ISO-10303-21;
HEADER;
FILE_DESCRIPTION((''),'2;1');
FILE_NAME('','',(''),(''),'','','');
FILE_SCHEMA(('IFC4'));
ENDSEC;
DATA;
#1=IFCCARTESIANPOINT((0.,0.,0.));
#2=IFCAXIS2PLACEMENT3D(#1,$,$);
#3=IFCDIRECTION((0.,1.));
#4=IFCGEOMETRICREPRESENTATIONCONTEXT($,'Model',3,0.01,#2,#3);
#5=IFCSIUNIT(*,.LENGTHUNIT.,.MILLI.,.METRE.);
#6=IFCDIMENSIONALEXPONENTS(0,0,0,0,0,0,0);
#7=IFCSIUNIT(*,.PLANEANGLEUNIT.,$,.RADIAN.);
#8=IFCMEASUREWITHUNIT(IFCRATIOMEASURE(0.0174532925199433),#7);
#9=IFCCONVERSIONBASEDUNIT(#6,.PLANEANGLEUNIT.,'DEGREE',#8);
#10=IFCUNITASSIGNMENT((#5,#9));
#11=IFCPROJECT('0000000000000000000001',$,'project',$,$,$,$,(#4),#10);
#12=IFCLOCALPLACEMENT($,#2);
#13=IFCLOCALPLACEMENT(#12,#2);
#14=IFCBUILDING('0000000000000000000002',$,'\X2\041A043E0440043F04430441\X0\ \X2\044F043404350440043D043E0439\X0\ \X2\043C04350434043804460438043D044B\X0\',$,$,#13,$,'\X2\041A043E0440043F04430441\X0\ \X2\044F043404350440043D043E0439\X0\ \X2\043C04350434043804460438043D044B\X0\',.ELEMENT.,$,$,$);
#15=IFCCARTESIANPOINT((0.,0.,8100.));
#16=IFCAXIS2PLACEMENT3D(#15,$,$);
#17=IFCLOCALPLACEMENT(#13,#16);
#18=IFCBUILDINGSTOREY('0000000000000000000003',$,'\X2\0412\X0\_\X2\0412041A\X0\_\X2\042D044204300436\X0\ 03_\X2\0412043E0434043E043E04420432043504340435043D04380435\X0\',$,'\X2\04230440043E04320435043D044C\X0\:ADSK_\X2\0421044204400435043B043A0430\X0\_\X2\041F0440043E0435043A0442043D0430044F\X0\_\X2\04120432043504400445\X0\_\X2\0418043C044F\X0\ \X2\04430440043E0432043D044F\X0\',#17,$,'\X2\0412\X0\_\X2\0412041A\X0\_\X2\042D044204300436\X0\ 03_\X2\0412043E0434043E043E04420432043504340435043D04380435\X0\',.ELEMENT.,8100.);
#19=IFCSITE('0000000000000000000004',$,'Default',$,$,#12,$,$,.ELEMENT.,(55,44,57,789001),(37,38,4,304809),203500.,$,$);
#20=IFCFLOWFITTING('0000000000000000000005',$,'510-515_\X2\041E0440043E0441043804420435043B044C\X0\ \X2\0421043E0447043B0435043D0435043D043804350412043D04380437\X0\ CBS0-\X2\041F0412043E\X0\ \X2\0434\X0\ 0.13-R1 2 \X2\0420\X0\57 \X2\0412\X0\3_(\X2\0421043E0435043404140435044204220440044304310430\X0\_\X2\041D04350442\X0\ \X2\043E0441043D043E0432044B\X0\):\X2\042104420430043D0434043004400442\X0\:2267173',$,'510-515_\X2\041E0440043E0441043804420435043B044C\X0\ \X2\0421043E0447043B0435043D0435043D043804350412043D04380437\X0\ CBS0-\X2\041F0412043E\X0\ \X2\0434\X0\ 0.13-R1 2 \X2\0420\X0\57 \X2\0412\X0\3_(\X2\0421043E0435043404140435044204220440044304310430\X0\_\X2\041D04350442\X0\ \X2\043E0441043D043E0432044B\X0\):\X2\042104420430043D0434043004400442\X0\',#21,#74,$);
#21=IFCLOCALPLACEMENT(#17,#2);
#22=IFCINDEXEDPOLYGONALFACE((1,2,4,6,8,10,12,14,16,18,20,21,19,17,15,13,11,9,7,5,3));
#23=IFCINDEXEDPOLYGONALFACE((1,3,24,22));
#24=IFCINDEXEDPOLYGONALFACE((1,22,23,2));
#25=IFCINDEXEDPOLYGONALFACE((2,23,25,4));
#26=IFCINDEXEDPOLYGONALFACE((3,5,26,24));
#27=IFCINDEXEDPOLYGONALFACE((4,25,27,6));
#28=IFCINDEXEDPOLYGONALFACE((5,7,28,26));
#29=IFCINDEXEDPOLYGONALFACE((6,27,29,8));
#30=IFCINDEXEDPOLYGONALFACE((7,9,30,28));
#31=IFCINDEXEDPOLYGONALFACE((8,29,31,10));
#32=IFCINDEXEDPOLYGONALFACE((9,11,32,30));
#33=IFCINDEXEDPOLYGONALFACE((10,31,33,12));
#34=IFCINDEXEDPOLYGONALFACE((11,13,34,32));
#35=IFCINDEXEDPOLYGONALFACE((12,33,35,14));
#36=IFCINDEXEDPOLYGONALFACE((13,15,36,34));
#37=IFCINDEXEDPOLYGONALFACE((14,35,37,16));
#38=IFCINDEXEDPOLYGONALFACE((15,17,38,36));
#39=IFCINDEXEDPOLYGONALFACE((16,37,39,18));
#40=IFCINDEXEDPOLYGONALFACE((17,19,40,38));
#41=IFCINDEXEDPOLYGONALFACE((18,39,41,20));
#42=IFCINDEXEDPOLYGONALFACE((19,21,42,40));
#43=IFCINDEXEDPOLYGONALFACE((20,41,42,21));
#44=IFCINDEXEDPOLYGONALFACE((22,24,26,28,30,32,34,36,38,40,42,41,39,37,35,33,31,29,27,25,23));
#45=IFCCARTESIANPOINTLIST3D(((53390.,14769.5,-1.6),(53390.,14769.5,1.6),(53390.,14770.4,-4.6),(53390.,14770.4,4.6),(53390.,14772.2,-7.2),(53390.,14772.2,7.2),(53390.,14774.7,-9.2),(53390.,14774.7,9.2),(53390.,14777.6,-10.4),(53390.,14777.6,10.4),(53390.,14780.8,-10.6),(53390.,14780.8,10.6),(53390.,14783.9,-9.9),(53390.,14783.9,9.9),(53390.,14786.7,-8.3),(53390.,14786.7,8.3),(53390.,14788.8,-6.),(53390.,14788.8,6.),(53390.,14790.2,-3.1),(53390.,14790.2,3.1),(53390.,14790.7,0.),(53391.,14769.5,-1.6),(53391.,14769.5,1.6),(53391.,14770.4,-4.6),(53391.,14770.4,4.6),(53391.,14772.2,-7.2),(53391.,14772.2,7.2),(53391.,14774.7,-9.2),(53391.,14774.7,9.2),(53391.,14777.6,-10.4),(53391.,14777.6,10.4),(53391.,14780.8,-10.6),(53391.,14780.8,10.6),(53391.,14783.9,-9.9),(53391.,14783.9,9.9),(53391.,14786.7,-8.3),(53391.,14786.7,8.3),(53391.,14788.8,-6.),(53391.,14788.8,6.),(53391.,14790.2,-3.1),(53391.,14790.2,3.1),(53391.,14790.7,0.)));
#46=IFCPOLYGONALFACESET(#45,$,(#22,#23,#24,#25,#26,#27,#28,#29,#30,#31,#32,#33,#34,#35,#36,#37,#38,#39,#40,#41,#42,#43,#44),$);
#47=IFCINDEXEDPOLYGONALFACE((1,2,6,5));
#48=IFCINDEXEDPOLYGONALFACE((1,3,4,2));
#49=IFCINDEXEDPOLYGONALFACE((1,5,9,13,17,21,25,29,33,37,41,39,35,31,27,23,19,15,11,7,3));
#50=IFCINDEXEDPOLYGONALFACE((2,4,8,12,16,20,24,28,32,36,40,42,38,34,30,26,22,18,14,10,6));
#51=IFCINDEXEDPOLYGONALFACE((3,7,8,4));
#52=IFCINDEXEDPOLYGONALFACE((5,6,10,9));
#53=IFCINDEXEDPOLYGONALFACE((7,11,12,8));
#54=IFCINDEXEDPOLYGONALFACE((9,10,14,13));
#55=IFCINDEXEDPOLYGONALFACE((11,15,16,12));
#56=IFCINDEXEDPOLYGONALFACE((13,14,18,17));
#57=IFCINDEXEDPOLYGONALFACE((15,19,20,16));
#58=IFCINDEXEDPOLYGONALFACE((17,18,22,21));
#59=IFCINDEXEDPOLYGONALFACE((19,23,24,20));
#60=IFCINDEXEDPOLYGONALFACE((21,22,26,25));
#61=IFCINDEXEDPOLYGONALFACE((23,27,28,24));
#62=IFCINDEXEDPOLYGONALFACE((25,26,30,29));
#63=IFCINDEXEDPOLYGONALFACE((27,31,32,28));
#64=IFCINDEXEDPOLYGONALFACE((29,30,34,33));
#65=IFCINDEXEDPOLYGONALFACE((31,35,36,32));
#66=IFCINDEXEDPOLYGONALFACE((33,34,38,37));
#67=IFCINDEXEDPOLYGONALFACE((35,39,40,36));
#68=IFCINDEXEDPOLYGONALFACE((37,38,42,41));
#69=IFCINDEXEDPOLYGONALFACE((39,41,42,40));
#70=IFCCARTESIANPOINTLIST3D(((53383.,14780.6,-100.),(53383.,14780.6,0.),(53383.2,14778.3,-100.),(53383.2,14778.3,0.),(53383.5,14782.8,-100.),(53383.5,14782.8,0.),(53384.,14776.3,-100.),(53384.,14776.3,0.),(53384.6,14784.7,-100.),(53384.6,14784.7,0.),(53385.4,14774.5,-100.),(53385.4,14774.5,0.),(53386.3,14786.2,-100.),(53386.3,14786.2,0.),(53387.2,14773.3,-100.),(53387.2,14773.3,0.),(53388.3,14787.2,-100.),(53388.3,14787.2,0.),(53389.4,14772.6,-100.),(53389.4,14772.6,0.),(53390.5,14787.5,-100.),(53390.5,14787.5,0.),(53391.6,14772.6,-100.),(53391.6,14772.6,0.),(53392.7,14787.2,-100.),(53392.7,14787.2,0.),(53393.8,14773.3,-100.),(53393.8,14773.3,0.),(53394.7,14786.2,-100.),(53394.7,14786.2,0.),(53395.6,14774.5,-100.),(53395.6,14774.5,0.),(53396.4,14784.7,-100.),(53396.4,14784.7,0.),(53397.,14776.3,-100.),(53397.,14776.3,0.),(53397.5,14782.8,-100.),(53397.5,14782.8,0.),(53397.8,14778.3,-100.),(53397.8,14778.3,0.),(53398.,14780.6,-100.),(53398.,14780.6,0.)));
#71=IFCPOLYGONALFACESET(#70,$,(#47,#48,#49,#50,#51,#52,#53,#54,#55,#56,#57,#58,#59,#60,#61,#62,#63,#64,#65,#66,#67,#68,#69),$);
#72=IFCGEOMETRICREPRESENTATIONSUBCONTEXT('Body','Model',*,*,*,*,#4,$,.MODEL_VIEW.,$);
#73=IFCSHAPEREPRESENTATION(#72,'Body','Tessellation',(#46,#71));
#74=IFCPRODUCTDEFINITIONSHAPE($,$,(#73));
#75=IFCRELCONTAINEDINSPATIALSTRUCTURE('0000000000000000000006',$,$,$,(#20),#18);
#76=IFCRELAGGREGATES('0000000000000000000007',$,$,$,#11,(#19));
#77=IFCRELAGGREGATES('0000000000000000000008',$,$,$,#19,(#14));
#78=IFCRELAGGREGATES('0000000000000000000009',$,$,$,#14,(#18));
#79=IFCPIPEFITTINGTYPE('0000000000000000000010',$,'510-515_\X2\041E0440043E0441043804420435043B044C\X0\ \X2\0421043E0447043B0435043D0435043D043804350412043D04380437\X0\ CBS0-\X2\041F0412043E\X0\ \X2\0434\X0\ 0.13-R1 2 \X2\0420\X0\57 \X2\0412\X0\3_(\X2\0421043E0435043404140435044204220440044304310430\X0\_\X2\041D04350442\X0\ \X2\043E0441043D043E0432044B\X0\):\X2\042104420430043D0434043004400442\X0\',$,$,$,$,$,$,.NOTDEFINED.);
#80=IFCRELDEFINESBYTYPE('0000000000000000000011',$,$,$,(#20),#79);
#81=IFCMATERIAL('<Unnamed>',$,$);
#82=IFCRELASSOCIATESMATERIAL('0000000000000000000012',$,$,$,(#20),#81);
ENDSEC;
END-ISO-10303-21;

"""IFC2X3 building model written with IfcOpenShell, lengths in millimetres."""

from ifc_helpers import new_model, entity, si_unit, converted_unit, direction, frame, origin, origin_2d_with_axis, place, context, subcontext, project, spatial, circle, extrude, source, transform, mapped, material, type_object, type_shapes, element, save


model = new_model("IFC2X3")

# Units and contexts
model_context = context("Model", 3, precision=0.01, world=origin(), true_north=direction((0.0, 1.0)))
body_context = subcontext(model_context, "Body", "Model", "MODEL_VIEW")
ifc_project = project(units=[si_unit("LENGTHUNIT", "METRE", prefix="MILLI"), converted_unit("PLANEANGLEUNIT", "DEGREE", entity("IfcRatioMeasure", 0.0174532925199433), si_unit("PLANEANGLEUNIT", "RADIAN"), dimensions=[0, 0, 0, 0, 0, 0, 0])], contexts=[model_context])

# Site, building, storey
site_placement = place(None, origin())
site = spatial("IfcSite", under=ifc_project, at=site_placement, Name="Default", CompositionType="ELEMENT", RefLatitude=(55, 44, 57, 789001), RefLongitude=(37, 38, 4, 304809), RefElevation=203500.0)
building_placement = place(site_placement, origin())
building = spatial("IfcBuilding", under=site, at=building_placement, Name="Корпус ядерной медицины", LongName="Корпус ядерной медицины", CompositionType="ELEMENT")
storey_placement = place(building_placement, frame((0.0, 0.0, 8100.0)))
storey = spatial("IfcBuildingStorey", under=building, at=storey_placement, Name="В_ВК_Этаж 03_Водоотведение", ObjectType="Уровень:ADSK_Стрелка_Проектная_Вверх_Имя уровня", LongName="В_ВК_Этаж 03_Водоотведение", CompositionType="ELEMENT", Elevation=8100.0)

# Flow fitting
ifc_material_1 = material(Name="<Unnamed>")
pipe_fitting_type = type_object("IfcPipeFittingType", Name="510-515_Ороситель СочленениеВниз CBS0-ПВо д 0.13-R1 2 Р57 В3_(СоедДетТруба_Нет основы):Стандарт", PredefinedType="NOTDEFINED")
shared_shape_1 = source(origin(), body_context, "Body", "SweptSolid", [
    extrude(circle(Radius=10.7, at=origin_2d_with_axis()), frame((-0.5, 0.0, 0.0), z_axis=(1.0, 0.0, 0.0), x_axis=(0.0, 1.0, 0.0)), (0.0, 0.0, 1.0), 1.0),
    extrude(circle(Radius=7.5, at=origin_2d_with_axis()), frame((0.0, 0.0, -100.0), z_axis=(0.0, 0.0, 1.0), x_axis=(0.0, 1.0, 0.0)), (0.0, 0.0, 1.0), 100.0),
])
type_shapes(pipe_fitting_type, [shared_shape_1])
flow_fitting_placement = place(storey_placement, frame((53390.5, 14780.0, 0.0)))
element("IfcFlowFitting", 1, at=flow_fitting_placement, inside=storey, type_object=pipe_fitting_type, material=ifc_material_1, Name="510-515_Ороситель СочленениеВниз CBS0-ПВо д 0.13-R1 2 Р57 В3_(СоедДетТруба_Нет основы):Стандарт:2267173", ObjectType="510-515_Ороситель СочленениеВниз CBS0-ПВо д 0.13-R1 2 Р57 В3_(СоедДетТруба_Нет основы):Стандарт", context=body_context, shape_type="MappedRepresentation", body=[
    mapped(shared_shape_1, transform((0.0, 0.0, 0.0), scale=1.0)),
])

save(model, "model.ifc")
